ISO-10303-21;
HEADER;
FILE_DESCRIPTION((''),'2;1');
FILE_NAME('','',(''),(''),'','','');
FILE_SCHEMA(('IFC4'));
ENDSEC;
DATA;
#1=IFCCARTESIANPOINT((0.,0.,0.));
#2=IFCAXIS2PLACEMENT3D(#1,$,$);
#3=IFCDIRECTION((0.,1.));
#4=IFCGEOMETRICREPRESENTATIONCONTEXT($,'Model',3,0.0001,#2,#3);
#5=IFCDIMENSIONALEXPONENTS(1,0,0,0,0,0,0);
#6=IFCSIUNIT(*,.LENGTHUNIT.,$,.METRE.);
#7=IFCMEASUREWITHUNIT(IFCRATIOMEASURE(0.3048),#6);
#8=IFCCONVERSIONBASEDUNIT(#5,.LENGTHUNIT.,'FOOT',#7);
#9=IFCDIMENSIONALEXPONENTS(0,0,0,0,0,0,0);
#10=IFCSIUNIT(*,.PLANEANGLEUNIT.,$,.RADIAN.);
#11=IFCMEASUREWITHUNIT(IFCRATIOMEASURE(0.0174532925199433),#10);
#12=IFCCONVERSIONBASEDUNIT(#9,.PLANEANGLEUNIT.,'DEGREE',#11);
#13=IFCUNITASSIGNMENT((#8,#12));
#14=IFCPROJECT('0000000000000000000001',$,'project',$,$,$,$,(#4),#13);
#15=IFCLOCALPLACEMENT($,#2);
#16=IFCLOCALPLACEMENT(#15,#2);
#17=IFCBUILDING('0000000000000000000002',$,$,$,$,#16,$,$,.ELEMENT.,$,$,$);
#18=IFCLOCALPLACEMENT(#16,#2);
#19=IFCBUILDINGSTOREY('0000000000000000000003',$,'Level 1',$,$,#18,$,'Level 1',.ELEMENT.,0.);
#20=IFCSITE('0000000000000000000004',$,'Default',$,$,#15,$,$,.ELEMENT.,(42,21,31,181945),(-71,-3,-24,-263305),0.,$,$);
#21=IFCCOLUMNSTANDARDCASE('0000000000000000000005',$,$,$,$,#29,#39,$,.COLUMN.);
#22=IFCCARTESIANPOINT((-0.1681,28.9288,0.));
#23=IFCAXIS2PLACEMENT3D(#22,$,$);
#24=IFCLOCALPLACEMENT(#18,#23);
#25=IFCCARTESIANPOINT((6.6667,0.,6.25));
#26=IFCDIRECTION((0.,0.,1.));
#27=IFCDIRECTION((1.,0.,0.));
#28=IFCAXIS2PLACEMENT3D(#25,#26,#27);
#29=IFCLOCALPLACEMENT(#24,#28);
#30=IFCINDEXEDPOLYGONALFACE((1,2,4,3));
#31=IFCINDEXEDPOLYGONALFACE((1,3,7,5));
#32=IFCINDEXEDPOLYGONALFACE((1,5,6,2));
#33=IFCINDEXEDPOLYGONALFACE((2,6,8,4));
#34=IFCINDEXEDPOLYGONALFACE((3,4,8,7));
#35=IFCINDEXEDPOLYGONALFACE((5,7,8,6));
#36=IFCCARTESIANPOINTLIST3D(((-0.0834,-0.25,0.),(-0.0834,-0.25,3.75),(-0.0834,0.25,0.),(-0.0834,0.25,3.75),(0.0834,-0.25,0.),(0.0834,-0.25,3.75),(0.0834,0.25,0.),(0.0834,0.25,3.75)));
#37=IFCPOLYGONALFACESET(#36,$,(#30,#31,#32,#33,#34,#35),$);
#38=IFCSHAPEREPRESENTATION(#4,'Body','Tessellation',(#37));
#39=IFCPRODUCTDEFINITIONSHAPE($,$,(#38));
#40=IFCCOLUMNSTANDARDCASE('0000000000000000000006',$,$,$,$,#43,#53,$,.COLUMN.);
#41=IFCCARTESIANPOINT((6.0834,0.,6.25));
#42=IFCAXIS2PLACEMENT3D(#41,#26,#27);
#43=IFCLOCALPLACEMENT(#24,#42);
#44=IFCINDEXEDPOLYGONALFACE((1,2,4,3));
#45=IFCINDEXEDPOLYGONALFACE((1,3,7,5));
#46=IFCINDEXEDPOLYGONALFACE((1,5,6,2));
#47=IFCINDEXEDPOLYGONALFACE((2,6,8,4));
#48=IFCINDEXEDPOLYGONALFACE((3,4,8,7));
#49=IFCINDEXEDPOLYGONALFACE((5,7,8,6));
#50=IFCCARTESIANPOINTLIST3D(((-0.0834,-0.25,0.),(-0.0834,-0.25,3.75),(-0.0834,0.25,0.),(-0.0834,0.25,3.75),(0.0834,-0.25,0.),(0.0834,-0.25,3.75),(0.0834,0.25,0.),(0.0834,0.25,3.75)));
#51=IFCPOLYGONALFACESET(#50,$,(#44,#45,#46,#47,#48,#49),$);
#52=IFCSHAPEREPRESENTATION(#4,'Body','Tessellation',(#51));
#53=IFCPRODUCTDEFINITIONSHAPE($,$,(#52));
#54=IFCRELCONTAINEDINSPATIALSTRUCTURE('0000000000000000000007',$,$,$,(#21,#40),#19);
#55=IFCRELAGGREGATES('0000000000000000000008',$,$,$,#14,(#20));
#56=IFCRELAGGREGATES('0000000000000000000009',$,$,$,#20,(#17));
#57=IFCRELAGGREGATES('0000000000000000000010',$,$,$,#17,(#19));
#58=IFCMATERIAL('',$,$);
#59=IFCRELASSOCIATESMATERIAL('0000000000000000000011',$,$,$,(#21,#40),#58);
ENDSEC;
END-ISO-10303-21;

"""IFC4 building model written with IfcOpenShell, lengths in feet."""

from ifc_helpers import new_model, entity, si_unit, converted_unit, direction, frame, origin, place, context, project, spatial, rectangle, extrude, material, element, save


model = new_model("IFC4")

# Units and contexts
model_context = context("Model", 3, precision=0.0001, world=origin(), true_north=direction((0.0, 1.0)))
ifc_project = project(units=[converted_unit("LENGTHUNIT", "FOOT", entity("IfcRatioMeasure", 0.3048), si_unit("LENGTHUNIT", "METRE"), dimensions=[1, 0, 0, 0, 0, 0, 0]), converted_unit("PLANEANGLEUNIT", "DEGREE", entity("IfcRatioMeasure", 0.0174532925199433), si_unit("PLANEANGLEUNIT", "RADIAN"), dimensions=[0, 0, 0, 0, 0, 0, 0])], contexts=[model_context])

# Site, building, storey
site_placement = place(None, origin())
site = spatial("IfcSite", under=ifc_project, at=site_placement, Name="Default", CompositionType="ELEMENT", RefLatitude=(42, 21, 31, 181945), RefLongitude=(-71, -3, -24, -263305), RefElevation=0.0)
building_placement = place(site_placement, origin())
building = spatial("IfcBuilding", under=site, at=building_placement, CompositionType="ELEMENT")
storey_placement = place(building_placement, origin())
storey = spatial("IfcBuildingStorey", under=building, at=storey_placement, Name="Level 1", LongName="Level 1", CompositionType="ELEMENT", Elevation=0.0)

# Columns
ifc_material = material(Name="")
placement = place(storey_placement, frame((-0.1681, 28.9288, 0.0)))
for number, where, z_axis, x_axis in (
    (1, (6.6667, 0.0, 6.25), (0.0, 0.0, 1.0), (1.0, 0.0, 0.0)),
    (2, (6.0834, 0.0, 6.25), (0.0, 0.0, 1.0), (1.0, 0.0, 0.0)),
):
    element("IfcColumnStandardCase", number, at=place(placement, frame(where, z_axis=z_axis, x_axis=x_axis)), inside=storey, material=ifc_material, PredefinedType="COLUMN", context=model_context, shape_type="SweptSolid", body=[
        extrude(rectangle(XDim=0.1667, YDim=0.5), origin(), (0.0, 0.0, 1.0), 3.75),
    ])

save(model, "model.ifc")
